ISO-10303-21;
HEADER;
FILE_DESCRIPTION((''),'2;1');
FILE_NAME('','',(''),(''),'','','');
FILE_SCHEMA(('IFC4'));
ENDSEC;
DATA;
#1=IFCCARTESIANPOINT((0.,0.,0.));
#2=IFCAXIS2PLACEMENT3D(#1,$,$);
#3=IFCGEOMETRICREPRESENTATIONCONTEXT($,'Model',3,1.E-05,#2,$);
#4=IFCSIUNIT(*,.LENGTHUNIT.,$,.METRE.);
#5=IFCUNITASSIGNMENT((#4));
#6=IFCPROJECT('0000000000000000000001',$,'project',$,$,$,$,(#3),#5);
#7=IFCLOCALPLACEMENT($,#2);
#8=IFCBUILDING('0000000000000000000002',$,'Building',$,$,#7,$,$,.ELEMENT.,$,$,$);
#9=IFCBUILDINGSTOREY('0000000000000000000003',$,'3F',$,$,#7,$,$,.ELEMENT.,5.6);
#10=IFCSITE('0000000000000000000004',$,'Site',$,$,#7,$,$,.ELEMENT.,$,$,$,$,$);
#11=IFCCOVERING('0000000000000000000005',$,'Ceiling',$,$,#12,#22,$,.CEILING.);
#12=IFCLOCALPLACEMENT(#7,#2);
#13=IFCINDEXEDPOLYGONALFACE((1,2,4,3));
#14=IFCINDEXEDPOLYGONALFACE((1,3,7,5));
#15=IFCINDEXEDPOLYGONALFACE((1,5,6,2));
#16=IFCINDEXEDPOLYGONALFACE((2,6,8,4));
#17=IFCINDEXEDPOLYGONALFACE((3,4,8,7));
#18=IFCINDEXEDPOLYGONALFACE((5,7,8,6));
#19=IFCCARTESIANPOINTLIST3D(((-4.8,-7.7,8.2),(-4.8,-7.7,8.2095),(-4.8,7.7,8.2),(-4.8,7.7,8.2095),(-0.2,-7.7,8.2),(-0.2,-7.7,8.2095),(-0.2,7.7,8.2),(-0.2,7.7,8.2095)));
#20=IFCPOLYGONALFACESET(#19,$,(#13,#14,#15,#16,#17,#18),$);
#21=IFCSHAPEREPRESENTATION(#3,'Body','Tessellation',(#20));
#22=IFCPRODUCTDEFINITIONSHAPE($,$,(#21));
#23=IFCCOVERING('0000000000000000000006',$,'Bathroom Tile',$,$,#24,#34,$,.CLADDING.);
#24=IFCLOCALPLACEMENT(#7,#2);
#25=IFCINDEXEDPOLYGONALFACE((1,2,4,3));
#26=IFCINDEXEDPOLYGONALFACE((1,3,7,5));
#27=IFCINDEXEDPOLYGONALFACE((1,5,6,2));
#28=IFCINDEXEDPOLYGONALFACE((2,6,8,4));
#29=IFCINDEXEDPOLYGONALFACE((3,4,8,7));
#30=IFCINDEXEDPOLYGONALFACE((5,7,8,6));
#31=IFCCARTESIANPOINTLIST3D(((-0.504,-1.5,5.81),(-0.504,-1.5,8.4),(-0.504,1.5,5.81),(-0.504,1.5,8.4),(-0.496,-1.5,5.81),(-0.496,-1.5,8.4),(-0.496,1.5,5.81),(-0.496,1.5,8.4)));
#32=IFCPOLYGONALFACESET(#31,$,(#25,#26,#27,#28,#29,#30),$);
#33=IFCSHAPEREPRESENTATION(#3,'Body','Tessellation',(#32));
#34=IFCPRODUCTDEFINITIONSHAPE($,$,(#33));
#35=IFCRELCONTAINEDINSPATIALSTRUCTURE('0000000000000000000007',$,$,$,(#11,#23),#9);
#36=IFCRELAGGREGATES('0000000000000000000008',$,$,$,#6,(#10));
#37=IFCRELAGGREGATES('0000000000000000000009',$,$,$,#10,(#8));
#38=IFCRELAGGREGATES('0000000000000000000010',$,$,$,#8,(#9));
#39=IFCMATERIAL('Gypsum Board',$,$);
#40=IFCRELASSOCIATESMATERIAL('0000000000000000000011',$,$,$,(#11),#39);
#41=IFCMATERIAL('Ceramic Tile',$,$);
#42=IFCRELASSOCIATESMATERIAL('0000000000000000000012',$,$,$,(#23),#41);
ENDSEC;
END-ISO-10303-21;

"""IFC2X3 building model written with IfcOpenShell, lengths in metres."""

from ifc_helpers import new_model, si_unit, frame, origin, origin_2d, place, context, project, spatial, rectangle, extrude, material, element, save


model = new_model("IFC2X3")

# Units and contexts
model_context = context("Model", 3, precision=1e-05, world=origin())
ifc_project = project(units=[si_unit("LENGTHUNIT", "METRE")], contexts=[model_context])

# Site, building, storey
placement = place(None, origin())
site = spatial("IfcSite", under=ifc_project, at=placement, Name="Site", CompositionType="ELEMENT")
building = spatial("IfcBuilding", under=site, at=placement, Name="Building", CompositionType="ELEMENT")
storey = spatial("IfcBuildingStorey", under=building, at=placement, Name="3F", CompositionType="ELEMENT", Elevation=5.6)

# Shared definitions
ifc_material_1 = material(Name="Gypsum Board")

# Coverings
ifc_material_2 = material(Name="Ceramic Tile")
covering_1_placement = place(None, frame((-2.5, 0.0, 8.2)))
element("IfcCovering", 1, at=covering_1_placement, inside=storey, material=ifc_material_1, Name="Ceiling", PredefinedType="CEILING", context=model_context, shape_type="SweptSolid", body=[
    extrude(rectangle(XDim=4.6, YDim=15.4, at=origin_2d()), origin(), (0.0, 0.0, 1.0), 0.0095),
])
covering_2_placement = place(None, frame((-0.5, 0.0, 5.81)))
element("IfcCovering", 2, at=covering_2_placement, inside=storey, material=ifc_material_2, Name="Bathroom Tile", PredefinedType="CLADDING", context=model_context, shape_type="SweptSolid", body=[
    extrude(rectangle(XDim=0.008, YDim=3.0, at=origin_2d()), origin(), (0.0, 0.0, 1.0), 2.59),
])

save(model, "model.ifc")
